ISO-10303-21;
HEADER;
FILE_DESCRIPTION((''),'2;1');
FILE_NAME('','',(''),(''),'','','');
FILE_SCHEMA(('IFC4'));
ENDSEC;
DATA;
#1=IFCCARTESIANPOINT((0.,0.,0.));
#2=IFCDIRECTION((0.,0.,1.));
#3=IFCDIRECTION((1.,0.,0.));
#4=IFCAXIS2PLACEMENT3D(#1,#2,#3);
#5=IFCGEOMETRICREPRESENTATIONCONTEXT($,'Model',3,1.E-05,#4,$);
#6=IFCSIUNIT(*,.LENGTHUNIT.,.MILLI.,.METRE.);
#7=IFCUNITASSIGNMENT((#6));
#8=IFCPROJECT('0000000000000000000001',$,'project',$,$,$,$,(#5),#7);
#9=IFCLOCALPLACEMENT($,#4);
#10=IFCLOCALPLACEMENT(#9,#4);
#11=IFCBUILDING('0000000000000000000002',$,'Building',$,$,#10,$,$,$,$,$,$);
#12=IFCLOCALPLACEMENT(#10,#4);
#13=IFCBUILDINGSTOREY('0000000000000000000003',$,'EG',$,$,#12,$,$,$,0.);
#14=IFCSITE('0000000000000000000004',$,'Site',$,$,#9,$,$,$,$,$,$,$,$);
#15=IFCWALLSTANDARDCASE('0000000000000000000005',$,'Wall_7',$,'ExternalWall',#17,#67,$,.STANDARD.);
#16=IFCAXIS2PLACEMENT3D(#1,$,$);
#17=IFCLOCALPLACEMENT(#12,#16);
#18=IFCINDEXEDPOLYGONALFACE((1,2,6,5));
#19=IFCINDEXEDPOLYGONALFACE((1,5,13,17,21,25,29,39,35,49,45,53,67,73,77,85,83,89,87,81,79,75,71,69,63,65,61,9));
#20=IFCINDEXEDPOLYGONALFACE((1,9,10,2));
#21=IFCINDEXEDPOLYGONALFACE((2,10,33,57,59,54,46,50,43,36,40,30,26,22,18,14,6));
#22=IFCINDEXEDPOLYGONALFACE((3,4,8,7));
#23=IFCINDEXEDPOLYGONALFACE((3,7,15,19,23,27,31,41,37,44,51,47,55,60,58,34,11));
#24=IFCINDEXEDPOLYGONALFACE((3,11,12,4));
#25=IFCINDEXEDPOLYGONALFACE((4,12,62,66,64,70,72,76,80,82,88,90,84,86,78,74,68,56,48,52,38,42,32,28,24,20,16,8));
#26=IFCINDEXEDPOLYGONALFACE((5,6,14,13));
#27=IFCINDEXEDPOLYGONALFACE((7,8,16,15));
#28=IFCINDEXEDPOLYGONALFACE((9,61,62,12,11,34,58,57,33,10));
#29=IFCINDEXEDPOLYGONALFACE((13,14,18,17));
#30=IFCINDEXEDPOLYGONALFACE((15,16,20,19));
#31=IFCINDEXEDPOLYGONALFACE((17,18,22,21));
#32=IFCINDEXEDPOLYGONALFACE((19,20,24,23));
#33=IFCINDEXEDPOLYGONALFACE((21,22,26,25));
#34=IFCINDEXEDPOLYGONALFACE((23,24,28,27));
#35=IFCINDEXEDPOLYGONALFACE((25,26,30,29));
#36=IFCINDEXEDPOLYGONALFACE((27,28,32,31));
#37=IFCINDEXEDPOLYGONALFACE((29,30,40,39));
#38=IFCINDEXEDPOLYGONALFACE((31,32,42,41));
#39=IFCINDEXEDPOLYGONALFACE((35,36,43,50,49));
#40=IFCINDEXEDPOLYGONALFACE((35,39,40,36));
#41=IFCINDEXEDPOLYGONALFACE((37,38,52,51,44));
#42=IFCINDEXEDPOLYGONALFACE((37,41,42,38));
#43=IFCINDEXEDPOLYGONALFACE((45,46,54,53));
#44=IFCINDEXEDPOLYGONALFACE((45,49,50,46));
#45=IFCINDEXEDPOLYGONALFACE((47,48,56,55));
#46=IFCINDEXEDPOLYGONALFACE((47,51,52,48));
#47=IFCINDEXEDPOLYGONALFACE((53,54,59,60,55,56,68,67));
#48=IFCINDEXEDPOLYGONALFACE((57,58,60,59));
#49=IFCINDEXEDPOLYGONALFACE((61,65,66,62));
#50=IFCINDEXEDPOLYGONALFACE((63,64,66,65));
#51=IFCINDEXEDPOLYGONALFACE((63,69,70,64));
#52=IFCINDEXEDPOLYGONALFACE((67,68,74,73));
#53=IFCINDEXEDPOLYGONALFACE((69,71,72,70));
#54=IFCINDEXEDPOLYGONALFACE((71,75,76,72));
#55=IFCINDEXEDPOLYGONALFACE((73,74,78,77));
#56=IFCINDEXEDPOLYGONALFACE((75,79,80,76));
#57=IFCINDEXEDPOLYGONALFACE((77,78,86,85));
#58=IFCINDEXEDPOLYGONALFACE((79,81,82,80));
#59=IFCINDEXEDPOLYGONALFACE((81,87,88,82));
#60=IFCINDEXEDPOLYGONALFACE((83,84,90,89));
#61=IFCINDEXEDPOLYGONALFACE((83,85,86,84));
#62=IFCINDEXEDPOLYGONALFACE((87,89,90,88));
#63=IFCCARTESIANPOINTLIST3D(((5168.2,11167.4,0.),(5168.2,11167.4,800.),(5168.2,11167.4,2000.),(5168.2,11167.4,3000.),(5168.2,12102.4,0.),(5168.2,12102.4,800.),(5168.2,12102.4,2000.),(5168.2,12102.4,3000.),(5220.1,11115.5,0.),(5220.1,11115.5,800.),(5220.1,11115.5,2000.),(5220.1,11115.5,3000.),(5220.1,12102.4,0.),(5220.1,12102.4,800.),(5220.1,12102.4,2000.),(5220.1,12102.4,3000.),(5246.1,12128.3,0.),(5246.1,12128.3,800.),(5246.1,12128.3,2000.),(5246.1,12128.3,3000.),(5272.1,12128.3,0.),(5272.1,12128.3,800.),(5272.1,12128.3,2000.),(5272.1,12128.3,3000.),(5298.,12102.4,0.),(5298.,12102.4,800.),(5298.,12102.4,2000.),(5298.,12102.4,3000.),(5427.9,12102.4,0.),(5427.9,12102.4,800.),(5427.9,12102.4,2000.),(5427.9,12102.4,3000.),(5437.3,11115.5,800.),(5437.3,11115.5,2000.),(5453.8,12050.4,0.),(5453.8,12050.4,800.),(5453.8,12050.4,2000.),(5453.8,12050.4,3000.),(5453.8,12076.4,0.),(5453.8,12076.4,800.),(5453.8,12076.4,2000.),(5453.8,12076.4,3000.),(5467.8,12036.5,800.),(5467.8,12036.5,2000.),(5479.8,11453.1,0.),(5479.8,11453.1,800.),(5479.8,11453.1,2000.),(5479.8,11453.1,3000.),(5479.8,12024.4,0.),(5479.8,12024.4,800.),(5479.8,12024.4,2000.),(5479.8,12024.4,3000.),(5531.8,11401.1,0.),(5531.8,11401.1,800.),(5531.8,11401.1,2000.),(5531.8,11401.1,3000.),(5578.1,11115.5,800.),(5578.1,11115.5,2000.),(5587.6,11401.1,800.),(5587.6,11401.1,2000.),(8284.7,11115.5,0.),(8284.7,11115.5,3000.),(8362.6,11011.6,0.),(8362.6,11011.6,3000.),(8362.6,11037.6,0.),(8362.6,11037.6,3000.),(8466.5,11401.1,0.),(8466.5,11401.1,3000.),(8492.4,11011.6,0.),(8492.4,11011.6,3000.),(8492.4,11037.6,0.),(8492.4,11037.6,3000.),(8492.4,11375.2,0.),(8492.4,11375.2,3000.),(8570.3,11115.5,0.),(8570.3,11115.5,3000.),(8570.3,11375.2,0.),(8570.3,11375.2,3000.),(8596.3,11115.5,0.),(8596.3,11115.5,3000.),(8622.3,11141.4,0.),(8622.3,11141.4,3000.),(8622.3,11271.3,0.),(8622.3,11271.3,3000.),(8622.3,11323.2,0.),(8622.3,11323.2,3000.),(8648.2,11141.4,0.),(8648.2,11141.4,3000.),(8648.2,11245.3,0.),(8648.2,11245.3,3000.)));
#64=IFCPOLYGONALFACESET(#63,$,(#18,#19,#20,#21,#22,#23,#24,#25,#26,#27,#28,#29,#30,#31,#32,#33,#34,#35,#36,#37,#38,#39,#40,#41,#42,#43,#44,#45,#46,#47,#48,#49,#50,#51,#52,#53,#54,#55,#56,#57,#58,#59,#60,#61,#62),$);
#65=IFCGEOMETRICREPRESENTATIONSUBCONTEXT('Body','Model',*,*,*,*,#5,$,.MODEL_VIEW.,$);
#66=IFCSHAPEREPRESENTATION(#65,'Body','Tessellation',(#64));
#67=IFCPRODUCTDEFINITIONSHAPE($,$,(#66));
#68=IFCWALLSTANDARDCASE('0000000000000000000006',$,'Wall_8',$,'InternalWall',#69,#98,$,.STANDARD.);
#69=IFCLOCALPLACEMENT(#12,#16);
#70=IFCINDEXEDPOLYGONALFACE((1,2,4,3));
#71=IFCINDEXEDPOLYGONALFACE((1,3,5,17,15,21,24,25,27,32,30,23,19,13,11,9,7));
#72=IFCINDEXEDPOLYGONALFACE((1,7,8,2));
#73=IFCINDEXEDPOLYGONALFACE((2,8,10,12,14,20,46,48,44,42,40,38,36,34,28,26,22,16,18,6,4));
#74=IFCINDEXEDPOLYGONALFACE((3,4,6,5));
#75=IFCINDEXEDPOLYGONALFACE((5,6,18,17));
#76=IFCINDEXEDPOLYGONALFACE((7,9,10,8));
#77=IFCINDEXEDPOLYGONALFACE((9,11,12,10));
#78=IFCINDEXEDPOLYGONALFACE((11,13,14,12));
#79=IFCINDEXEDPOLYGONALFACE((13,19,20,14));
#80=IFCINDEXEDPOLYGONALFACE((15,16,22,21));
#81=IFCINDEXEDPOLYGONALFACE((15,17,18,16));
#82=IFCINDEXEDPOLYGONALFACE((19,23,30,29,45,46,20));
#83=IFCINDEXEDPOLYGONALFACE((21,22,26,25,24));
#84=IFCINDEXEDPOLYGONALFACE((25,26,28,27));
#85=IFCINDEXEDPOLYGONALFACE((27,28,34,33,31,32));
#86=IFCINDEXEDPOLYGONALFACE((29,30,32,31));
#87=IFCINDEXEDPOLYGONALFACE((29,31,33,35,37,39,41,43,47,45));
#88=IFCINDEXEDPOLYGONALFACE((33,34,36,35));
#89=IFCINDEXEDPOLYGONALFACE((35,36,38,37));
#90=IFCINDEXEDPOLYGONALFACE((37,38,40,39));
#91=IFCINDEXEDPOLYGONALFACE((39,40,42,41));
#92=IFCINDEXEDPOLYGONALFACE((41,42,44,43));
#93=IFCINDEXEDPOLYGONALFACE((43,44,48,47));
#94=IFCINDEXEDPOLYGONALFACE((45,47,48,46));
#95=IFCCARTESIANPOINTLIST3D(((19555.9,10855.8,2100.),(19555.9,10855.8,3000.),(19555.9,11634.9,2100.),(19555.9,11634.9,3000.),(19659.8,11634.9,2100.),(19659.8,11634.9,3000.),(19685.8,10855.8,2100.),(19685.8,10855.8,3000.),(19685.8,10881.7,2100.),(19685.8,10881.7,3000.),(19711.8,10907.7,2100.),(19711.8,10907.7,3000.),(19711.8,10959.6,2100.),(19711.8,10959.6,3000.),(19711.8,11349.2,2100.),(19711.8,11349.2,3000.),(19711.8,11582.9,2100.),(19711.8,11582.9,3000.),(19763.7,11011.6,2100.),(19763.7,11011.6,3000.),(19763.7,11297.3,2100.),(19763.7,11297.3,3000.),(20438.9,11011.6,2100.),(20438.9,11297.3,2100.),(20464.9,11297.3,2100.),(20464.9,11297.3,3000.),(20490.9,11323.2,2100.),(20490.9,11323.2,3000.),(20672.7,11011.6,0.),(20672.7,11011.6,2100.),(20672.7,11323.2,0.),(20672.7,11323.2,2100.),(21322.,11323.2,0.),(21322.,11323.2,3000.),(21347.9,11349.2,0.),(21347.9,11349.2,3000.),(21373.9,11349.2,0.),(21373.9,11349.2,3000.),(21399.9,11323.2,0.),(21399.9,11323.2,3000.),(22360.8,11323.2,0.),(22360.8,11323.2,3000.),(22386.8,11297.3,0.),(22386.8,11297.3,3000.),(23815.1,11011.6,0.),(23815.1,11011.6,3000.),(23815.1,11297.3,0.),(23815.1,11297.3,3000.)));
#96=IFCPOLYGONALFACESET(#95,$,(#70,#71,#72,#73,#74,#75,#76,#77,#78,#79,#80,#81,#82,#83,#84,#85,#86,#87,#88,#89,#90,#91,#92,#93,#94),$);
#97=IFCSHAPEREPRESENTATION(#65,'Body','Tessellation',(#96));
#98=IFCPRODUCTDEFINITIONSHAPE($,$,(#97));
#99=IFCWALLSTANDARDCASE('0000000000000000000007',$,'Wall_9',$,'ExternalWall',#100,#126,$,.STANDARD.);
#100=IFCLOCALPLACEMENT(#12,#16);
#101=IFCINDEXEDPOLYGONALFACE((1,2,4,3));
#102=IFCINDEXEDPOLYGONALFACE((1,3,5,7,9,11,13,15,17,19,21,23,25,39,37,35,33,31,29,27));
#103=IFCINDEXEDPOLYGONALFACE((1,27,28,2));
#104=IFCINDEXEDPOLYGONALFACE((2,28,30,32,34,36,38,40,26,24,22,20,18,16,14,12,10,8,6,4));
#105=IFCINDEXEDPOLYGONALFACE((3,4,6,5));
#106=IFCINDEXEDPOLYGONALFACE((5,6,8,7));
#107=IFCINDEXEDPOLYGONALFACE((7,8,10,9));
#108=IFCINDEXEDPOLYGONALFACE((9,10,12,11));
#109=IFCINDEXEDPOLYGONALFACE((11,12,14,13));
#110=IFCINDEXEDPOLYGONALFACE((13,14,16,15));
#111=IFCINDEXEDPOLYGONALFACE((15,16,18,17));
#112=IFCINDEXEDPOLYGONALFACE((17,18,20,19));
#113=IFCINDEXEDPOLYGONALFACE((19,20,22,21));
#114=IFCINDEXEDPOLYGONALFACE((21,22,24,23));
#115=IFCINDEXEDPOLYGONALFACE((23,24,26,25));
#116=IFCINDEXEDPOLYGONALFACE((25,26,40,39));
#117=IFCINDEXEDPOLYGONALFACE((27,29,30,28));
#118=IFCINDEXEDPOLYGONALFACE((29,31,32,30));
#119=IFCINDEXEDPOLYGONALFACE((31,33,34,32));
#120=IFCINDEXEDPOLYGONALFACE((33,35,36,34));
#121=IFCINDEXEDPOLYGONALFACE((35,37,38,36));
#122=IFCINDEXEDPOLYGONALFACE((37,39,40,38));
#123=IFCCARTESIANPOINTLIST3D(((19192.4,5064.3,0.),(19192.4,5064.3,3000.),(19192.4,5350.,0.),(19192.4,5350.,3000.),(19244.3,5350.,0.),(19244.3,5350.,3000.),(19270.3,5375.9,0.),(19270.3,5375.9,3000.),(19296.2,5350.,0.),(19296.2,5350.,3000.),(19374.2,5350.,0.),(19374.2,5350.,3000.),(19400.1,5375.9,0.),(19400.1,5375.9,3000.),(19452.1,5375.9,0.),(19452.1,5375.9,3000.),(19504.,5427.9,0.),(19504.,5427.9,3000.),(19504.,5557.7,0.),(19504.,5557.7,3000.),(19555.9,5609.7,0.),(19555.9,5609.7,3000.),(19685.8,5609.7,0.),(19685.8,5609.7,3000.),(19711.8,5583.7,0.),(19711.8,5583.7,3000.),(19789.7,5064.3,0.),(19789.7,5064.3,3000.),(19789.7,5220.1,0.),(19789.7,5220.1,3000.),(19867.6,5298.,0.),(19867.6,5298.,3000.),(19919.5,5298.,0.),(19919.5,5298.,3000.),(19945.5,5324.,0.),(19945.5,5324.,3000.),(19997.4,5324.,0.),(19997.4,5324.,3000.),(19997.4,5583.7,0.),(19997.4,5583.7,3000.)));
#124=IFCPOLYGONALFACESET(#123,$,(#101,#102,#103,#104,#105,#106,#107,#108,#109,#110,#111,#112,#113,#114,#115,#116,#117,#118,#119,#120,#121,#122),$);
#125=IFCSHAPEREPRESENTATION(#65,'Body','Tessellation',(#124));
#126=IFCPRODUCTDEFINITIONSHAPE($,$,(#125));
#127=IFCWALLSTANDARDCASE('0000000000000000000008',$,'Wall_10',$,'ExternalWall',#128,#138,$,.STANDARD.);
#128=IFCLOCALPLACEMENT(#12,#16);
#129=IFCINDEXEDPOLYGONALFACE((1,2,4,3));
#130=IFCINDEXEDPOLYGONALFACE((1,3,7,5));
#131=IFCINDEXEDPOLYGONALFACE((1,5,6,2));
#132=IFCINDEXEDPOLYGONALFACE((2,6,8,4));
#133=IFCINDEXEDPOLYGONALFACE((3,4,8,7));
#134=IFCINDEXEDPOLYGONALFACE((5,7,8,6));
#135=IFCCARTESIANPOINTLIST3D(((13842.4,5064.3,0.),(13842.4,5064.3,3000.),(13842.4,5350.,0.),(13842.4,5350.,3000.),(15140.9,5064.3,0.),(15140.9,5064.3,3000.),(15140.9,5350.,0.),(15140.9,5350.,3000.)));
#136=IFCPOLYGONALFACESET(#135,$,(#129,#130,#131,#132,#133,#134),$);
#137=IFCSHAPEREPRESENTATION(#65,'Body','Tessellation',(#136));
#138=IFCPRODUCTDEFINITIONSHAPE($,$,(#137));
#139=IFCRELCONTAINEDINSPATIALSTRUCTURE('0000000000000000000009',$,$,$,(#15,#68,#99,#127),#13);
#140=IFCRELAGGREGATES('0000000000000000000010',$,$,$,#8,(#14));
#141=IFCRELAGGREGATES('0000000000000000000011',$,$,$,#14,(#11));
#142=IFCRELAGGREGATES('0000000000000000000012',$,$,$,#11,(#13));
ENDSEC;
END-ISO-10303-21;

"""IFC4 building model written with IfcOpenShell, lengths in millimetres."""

from ifc_helpers import new_model, si_unit, frame, origin_with_axes, place, context, subcontext, project, spatial, polyline, rectangle, outline, extrude, element, save


model = new_model("IFC4")

# Units and contexts
model_context = context("Model", 3, precision=1e-05, world=origin_with_axes())
body_context = subcontext(model_context, "Body", "Model", "MODEL_VIEW")
ifc_project = project(units=[si_unit("LENGTHUNIT", "METRE", prefix="MILLI")], contexts=[model_context])

# Site, building, storey
site_placement = place(None, origin_with_axes())
site = spatial("IfcSite", under=ifc_project, at=site_placement, Name="Site")
building_placement = place(site_placement, origin_with_axes())
building = spatial("IfcBuilding", under=site, at=building_placement, Name="Building")
storey_placement = place(building_placement, origin_with_axes())
storey = spatial("IfcBuildingStorey", under=building, at=storey_placement, Name="EG", Elevation=0.0)

# Walls, openings
wall_1_placement = place(storey_placement, origin_with_axes())
wall_1 = element("IfcWallStandardCase", 1, at=wall_1_placement, inside=storey, Name="Wall_7", ObjectType="ExternalWall", PredefinedType="STANDARD", context=body_context, shape_type="SweptSolid", body=[
    extrude(outline(polyline([(8362.6, 11011.6, 0.0), (8362.6, 11037.6, 0.0), (8284.7, 11115.5, 0.0), (5220.1, 11115.5, 0.0), (5168.2, 11167.4, 0.0), (5168.2, 12102.4, 0.0), (5220.1, 12102.4, 0.0), (5246.1, 12128.3, 0.0), (5272.1, 12128.3, 0.0), (5298.0, 12102.4, 0.0), (5427.9, 12102.4, 0.0), (5453.8, 12076.4, 0.0), (5453.8, 12050.4, 0.0), (5479.8, 12024.4, 0.0), (5479.8, 11453.1, 0.0), (5531.8, 11401.1, 0.0), (8466.5, 11401.1, 0.0), (8492.4, 11375.2, 0.0), (8570.3, 11375.2, 0.0), (8622.3, 11323.2, 0.0), (8622.3, 11271.3, 0.0), (8648.2, 11245.3, 0.0), (8648.2, 11141.4, 0.0), (8622.3, 11141.4, 0.0), (8596.3, 11115.5, 0.0), (8570.3, 11115.5, 0.0), (8492.4, 11037.6, 0.0), (8492.4, 11011.6, 0.0), (8362.6, 11011.6, 0.0)])), origin_with_axes(), (0.0, 0.0, 1.0), 3000.0),
])
opening_1_placement = place(wall_1_placement, origin_with_axes())
element("IfcOpeningElement", 2, at=opening_1_placement, inside=storey, cuts=wall_1, context=body_context, shape_type="SweptSolid", body=[
    extrude(rectangle(XDim=600.0, YDim=1014.0), frame((5294.6, 11620.3, 800.0), z_axis=(0.0, 0.0, 1.0), x_axis=(0.999454, -0.03304, 0.0)), (0.0, 0.0, 1.0), 1200.0),
])
opening_2_placement = place(wall_1_placement, origin_with_axes())
element("IfcOpeningElement", 3, at=opening_2_placement, inside=storey, cuts=wall_1, context=body_context, shape_type="SweptSolid", body=[
    extrude(rectangle(XDim=600.0, YDim=1014.0), frame((5154.0, 11624.9, 800.0), z_axis=(0.0, 0.0, 1.0), x_axis=(0.999454, -0.03304, 0.0)), (0.0, 0.0, 1.0), 1200.0),
])
wall_2_placement = place(storey_placement, origin_with_axes())
wall_2 = element("IfcWallStandardCase", 4, at=wall_2_placement, inside=storey, Name="Wall_8", ObjectType="InternalWall", PredefinedType="STANDARD", context=body_context, shape_type="SweptSolid", body=[
    extrude(outline(polyline([(19555.9, 10855.8, 0.0), (19555.9, 11634.9, 0.0), (19659.8, 11634.9, 0.0), (19711.8, 11582.9, 0.0), (19711.8, 11349.2, 0.0), (19763.7, 11297.3, 0.0), (20464.9, 11297.3, 0.0), (20490.9, 11323.2, 0.0), (21322.0, 11323.2, 0.0), (21347.9, 11349.2, 0.0), (21373.9, 11349.2, 0.0), (21399.9, 11323.2, 0.0), (22360.8, 11323.2, 0.0), (22386.8, 11297.3, 0.0), (23815.1, 11297.3, 0.0), (23815.1, 11011.6, 0.0), (19763.7, 11011.6, 0.0), (19711.8, 10959.6, 0.0), (19711.8, 10907.7, 0.0), (19685.8, 10881.7, 0.0), (19685.8, 10855.8, 0.0), (19555.9, 10855.8, 0.0)])), origin_with_axes(), (0.0, 0.0, 1.0), 3000.0),
])
opening_3_placement = place(wall_2_placement, origin_with_axes())
element("IfcOpeningElement", 5, at=opening_3_placement, inside=storey, cuts=wall_2, context=body_context, shape_type="SweptSolid", body=[
    extrude(rectangle(XDim=1116.7, YDim=779.1), frame((20114.3, 11245.3, 0.0), z_axis=(0.0, 0.0, 1.0), x_axis=(1.0, 0.0, 0.0)), (0.0, 0.0, 1.0), 2100.0),
])
opening_4_placement = place(wall_2_placement, origin_with_axes())
element("IfcOpeningElement", 6, at=opening_4_placement, inside=storey, cuts=wall_2, context=body_context, shape_type="SweptSolid", body=[
    extrude(rectangle(XDim=883.0, YDim=779.1), frame((19997.4, 11245.3, 0.0), z_axis=(0.0, 0.0, 1.0), x_axis=(1.0, 0.0, 0.0)), (0.0, 0.0, 1.0), 2100.0),
])
wall_3_placement = place(storey_placement, origin_with_axes())
wall_3 = element("IfcWallStandardCase", 7, at=wall_3_placement, inside=storey, Name="Wall_9", ObjectType="ExternalWall", PredefinedType="STANDARD", context=body_context, shape_type="SweptSolid", body=[
    extrude(outline(polyline([(19192.4, 5064.3, 0.0), (19192.4, 5350.0, 0.0), (19244.3, 5350.0, 0.0), (19270.3, 5375.9, 0.0), (19296.2, 5350.0, 0.0), (19374.2, 5350.0, 0.0), (19400.1, 5375.9, 0.0), (19452.1, 5375.9, 0.0), (19504.0, 5427.9, 0.0), (19504.0, 5557.7, 0.0), (19555.9, 5609.7, 0.0), (19685.8, 5609.7, 0.0), (19711.8, 5583.7, 0.0), (19997.4, 5583.7, 0.0), (19997.4, 5324.0, 0.0), (19945.5, 5324.0, 0.0), (19919.5, 5298.0, 0.0), (19867.6, 5298.0, 0.0), (19789.7, 5220.1, 0.0), (19789.7, 5064.3, 0.0), (19192.4, 5064.3, 0.0)])), origin_with_axes(), (0.0, 0.0, 1.0), 3000.0),
])
opening_5_placement = place(wall_3_placement, origin_with_axes())
element("IfcOpeningElement", 8, at=opening_5_placement, inside=storey, cuts=wall_3, context=body_context, shape_type="SweptSolid", body=[
    extrude(rectangle(XDim=1200.0, YDim=545.4), frame((18530.1, 5193.9, 800.0), z_axis=(0.0, 0.0, 1.0), x_axis=(1.0, 0.0, 0.0)), (0.0, 0.0, 1.0), 1200.0),
])
opening_6_placement = place(wall_3_placement, origin_with_axes())
element("IfcOpeningElement", 9, at=opening_6_placement, inside=storey, cuts=wall_3, context=body_context, shape_type="SweptSolid", body=[
    extrude(rectangle(XDim=1200.0, YDim=545.4), frame((21763.5, 5492.8, 800.0), z_axis=(0.0, 0.0, 1.0), x_axis=(1.0, 0.0, 0.0)), (0.0, 0.0, 1.0), 1200.0),
])

# Wall
wall_4_placement = place(storey_placement, origin_with_axes())
element("IfcWallStandardCase", 10, at=wall_4_placement, inside=storey, Name="Wall_10", ObjectType="ExternalWall", PredefinedType="STANDARD", context=body_context, shape_type="SweptSolid", body=[
    extrude(outline(polyline([(13842.4, 5064.3, 0.0), (13842.4, 5350.0, 0.0), (15140.9, 5350.0, 0.0), (15140.9, 5064.3, 0.0), (13842.4, 5064.3, 0.0)])), origin_with_axes(), (0.0, 0.0, 1.0), 3000.0),
])

save(model, "model.ifc")
